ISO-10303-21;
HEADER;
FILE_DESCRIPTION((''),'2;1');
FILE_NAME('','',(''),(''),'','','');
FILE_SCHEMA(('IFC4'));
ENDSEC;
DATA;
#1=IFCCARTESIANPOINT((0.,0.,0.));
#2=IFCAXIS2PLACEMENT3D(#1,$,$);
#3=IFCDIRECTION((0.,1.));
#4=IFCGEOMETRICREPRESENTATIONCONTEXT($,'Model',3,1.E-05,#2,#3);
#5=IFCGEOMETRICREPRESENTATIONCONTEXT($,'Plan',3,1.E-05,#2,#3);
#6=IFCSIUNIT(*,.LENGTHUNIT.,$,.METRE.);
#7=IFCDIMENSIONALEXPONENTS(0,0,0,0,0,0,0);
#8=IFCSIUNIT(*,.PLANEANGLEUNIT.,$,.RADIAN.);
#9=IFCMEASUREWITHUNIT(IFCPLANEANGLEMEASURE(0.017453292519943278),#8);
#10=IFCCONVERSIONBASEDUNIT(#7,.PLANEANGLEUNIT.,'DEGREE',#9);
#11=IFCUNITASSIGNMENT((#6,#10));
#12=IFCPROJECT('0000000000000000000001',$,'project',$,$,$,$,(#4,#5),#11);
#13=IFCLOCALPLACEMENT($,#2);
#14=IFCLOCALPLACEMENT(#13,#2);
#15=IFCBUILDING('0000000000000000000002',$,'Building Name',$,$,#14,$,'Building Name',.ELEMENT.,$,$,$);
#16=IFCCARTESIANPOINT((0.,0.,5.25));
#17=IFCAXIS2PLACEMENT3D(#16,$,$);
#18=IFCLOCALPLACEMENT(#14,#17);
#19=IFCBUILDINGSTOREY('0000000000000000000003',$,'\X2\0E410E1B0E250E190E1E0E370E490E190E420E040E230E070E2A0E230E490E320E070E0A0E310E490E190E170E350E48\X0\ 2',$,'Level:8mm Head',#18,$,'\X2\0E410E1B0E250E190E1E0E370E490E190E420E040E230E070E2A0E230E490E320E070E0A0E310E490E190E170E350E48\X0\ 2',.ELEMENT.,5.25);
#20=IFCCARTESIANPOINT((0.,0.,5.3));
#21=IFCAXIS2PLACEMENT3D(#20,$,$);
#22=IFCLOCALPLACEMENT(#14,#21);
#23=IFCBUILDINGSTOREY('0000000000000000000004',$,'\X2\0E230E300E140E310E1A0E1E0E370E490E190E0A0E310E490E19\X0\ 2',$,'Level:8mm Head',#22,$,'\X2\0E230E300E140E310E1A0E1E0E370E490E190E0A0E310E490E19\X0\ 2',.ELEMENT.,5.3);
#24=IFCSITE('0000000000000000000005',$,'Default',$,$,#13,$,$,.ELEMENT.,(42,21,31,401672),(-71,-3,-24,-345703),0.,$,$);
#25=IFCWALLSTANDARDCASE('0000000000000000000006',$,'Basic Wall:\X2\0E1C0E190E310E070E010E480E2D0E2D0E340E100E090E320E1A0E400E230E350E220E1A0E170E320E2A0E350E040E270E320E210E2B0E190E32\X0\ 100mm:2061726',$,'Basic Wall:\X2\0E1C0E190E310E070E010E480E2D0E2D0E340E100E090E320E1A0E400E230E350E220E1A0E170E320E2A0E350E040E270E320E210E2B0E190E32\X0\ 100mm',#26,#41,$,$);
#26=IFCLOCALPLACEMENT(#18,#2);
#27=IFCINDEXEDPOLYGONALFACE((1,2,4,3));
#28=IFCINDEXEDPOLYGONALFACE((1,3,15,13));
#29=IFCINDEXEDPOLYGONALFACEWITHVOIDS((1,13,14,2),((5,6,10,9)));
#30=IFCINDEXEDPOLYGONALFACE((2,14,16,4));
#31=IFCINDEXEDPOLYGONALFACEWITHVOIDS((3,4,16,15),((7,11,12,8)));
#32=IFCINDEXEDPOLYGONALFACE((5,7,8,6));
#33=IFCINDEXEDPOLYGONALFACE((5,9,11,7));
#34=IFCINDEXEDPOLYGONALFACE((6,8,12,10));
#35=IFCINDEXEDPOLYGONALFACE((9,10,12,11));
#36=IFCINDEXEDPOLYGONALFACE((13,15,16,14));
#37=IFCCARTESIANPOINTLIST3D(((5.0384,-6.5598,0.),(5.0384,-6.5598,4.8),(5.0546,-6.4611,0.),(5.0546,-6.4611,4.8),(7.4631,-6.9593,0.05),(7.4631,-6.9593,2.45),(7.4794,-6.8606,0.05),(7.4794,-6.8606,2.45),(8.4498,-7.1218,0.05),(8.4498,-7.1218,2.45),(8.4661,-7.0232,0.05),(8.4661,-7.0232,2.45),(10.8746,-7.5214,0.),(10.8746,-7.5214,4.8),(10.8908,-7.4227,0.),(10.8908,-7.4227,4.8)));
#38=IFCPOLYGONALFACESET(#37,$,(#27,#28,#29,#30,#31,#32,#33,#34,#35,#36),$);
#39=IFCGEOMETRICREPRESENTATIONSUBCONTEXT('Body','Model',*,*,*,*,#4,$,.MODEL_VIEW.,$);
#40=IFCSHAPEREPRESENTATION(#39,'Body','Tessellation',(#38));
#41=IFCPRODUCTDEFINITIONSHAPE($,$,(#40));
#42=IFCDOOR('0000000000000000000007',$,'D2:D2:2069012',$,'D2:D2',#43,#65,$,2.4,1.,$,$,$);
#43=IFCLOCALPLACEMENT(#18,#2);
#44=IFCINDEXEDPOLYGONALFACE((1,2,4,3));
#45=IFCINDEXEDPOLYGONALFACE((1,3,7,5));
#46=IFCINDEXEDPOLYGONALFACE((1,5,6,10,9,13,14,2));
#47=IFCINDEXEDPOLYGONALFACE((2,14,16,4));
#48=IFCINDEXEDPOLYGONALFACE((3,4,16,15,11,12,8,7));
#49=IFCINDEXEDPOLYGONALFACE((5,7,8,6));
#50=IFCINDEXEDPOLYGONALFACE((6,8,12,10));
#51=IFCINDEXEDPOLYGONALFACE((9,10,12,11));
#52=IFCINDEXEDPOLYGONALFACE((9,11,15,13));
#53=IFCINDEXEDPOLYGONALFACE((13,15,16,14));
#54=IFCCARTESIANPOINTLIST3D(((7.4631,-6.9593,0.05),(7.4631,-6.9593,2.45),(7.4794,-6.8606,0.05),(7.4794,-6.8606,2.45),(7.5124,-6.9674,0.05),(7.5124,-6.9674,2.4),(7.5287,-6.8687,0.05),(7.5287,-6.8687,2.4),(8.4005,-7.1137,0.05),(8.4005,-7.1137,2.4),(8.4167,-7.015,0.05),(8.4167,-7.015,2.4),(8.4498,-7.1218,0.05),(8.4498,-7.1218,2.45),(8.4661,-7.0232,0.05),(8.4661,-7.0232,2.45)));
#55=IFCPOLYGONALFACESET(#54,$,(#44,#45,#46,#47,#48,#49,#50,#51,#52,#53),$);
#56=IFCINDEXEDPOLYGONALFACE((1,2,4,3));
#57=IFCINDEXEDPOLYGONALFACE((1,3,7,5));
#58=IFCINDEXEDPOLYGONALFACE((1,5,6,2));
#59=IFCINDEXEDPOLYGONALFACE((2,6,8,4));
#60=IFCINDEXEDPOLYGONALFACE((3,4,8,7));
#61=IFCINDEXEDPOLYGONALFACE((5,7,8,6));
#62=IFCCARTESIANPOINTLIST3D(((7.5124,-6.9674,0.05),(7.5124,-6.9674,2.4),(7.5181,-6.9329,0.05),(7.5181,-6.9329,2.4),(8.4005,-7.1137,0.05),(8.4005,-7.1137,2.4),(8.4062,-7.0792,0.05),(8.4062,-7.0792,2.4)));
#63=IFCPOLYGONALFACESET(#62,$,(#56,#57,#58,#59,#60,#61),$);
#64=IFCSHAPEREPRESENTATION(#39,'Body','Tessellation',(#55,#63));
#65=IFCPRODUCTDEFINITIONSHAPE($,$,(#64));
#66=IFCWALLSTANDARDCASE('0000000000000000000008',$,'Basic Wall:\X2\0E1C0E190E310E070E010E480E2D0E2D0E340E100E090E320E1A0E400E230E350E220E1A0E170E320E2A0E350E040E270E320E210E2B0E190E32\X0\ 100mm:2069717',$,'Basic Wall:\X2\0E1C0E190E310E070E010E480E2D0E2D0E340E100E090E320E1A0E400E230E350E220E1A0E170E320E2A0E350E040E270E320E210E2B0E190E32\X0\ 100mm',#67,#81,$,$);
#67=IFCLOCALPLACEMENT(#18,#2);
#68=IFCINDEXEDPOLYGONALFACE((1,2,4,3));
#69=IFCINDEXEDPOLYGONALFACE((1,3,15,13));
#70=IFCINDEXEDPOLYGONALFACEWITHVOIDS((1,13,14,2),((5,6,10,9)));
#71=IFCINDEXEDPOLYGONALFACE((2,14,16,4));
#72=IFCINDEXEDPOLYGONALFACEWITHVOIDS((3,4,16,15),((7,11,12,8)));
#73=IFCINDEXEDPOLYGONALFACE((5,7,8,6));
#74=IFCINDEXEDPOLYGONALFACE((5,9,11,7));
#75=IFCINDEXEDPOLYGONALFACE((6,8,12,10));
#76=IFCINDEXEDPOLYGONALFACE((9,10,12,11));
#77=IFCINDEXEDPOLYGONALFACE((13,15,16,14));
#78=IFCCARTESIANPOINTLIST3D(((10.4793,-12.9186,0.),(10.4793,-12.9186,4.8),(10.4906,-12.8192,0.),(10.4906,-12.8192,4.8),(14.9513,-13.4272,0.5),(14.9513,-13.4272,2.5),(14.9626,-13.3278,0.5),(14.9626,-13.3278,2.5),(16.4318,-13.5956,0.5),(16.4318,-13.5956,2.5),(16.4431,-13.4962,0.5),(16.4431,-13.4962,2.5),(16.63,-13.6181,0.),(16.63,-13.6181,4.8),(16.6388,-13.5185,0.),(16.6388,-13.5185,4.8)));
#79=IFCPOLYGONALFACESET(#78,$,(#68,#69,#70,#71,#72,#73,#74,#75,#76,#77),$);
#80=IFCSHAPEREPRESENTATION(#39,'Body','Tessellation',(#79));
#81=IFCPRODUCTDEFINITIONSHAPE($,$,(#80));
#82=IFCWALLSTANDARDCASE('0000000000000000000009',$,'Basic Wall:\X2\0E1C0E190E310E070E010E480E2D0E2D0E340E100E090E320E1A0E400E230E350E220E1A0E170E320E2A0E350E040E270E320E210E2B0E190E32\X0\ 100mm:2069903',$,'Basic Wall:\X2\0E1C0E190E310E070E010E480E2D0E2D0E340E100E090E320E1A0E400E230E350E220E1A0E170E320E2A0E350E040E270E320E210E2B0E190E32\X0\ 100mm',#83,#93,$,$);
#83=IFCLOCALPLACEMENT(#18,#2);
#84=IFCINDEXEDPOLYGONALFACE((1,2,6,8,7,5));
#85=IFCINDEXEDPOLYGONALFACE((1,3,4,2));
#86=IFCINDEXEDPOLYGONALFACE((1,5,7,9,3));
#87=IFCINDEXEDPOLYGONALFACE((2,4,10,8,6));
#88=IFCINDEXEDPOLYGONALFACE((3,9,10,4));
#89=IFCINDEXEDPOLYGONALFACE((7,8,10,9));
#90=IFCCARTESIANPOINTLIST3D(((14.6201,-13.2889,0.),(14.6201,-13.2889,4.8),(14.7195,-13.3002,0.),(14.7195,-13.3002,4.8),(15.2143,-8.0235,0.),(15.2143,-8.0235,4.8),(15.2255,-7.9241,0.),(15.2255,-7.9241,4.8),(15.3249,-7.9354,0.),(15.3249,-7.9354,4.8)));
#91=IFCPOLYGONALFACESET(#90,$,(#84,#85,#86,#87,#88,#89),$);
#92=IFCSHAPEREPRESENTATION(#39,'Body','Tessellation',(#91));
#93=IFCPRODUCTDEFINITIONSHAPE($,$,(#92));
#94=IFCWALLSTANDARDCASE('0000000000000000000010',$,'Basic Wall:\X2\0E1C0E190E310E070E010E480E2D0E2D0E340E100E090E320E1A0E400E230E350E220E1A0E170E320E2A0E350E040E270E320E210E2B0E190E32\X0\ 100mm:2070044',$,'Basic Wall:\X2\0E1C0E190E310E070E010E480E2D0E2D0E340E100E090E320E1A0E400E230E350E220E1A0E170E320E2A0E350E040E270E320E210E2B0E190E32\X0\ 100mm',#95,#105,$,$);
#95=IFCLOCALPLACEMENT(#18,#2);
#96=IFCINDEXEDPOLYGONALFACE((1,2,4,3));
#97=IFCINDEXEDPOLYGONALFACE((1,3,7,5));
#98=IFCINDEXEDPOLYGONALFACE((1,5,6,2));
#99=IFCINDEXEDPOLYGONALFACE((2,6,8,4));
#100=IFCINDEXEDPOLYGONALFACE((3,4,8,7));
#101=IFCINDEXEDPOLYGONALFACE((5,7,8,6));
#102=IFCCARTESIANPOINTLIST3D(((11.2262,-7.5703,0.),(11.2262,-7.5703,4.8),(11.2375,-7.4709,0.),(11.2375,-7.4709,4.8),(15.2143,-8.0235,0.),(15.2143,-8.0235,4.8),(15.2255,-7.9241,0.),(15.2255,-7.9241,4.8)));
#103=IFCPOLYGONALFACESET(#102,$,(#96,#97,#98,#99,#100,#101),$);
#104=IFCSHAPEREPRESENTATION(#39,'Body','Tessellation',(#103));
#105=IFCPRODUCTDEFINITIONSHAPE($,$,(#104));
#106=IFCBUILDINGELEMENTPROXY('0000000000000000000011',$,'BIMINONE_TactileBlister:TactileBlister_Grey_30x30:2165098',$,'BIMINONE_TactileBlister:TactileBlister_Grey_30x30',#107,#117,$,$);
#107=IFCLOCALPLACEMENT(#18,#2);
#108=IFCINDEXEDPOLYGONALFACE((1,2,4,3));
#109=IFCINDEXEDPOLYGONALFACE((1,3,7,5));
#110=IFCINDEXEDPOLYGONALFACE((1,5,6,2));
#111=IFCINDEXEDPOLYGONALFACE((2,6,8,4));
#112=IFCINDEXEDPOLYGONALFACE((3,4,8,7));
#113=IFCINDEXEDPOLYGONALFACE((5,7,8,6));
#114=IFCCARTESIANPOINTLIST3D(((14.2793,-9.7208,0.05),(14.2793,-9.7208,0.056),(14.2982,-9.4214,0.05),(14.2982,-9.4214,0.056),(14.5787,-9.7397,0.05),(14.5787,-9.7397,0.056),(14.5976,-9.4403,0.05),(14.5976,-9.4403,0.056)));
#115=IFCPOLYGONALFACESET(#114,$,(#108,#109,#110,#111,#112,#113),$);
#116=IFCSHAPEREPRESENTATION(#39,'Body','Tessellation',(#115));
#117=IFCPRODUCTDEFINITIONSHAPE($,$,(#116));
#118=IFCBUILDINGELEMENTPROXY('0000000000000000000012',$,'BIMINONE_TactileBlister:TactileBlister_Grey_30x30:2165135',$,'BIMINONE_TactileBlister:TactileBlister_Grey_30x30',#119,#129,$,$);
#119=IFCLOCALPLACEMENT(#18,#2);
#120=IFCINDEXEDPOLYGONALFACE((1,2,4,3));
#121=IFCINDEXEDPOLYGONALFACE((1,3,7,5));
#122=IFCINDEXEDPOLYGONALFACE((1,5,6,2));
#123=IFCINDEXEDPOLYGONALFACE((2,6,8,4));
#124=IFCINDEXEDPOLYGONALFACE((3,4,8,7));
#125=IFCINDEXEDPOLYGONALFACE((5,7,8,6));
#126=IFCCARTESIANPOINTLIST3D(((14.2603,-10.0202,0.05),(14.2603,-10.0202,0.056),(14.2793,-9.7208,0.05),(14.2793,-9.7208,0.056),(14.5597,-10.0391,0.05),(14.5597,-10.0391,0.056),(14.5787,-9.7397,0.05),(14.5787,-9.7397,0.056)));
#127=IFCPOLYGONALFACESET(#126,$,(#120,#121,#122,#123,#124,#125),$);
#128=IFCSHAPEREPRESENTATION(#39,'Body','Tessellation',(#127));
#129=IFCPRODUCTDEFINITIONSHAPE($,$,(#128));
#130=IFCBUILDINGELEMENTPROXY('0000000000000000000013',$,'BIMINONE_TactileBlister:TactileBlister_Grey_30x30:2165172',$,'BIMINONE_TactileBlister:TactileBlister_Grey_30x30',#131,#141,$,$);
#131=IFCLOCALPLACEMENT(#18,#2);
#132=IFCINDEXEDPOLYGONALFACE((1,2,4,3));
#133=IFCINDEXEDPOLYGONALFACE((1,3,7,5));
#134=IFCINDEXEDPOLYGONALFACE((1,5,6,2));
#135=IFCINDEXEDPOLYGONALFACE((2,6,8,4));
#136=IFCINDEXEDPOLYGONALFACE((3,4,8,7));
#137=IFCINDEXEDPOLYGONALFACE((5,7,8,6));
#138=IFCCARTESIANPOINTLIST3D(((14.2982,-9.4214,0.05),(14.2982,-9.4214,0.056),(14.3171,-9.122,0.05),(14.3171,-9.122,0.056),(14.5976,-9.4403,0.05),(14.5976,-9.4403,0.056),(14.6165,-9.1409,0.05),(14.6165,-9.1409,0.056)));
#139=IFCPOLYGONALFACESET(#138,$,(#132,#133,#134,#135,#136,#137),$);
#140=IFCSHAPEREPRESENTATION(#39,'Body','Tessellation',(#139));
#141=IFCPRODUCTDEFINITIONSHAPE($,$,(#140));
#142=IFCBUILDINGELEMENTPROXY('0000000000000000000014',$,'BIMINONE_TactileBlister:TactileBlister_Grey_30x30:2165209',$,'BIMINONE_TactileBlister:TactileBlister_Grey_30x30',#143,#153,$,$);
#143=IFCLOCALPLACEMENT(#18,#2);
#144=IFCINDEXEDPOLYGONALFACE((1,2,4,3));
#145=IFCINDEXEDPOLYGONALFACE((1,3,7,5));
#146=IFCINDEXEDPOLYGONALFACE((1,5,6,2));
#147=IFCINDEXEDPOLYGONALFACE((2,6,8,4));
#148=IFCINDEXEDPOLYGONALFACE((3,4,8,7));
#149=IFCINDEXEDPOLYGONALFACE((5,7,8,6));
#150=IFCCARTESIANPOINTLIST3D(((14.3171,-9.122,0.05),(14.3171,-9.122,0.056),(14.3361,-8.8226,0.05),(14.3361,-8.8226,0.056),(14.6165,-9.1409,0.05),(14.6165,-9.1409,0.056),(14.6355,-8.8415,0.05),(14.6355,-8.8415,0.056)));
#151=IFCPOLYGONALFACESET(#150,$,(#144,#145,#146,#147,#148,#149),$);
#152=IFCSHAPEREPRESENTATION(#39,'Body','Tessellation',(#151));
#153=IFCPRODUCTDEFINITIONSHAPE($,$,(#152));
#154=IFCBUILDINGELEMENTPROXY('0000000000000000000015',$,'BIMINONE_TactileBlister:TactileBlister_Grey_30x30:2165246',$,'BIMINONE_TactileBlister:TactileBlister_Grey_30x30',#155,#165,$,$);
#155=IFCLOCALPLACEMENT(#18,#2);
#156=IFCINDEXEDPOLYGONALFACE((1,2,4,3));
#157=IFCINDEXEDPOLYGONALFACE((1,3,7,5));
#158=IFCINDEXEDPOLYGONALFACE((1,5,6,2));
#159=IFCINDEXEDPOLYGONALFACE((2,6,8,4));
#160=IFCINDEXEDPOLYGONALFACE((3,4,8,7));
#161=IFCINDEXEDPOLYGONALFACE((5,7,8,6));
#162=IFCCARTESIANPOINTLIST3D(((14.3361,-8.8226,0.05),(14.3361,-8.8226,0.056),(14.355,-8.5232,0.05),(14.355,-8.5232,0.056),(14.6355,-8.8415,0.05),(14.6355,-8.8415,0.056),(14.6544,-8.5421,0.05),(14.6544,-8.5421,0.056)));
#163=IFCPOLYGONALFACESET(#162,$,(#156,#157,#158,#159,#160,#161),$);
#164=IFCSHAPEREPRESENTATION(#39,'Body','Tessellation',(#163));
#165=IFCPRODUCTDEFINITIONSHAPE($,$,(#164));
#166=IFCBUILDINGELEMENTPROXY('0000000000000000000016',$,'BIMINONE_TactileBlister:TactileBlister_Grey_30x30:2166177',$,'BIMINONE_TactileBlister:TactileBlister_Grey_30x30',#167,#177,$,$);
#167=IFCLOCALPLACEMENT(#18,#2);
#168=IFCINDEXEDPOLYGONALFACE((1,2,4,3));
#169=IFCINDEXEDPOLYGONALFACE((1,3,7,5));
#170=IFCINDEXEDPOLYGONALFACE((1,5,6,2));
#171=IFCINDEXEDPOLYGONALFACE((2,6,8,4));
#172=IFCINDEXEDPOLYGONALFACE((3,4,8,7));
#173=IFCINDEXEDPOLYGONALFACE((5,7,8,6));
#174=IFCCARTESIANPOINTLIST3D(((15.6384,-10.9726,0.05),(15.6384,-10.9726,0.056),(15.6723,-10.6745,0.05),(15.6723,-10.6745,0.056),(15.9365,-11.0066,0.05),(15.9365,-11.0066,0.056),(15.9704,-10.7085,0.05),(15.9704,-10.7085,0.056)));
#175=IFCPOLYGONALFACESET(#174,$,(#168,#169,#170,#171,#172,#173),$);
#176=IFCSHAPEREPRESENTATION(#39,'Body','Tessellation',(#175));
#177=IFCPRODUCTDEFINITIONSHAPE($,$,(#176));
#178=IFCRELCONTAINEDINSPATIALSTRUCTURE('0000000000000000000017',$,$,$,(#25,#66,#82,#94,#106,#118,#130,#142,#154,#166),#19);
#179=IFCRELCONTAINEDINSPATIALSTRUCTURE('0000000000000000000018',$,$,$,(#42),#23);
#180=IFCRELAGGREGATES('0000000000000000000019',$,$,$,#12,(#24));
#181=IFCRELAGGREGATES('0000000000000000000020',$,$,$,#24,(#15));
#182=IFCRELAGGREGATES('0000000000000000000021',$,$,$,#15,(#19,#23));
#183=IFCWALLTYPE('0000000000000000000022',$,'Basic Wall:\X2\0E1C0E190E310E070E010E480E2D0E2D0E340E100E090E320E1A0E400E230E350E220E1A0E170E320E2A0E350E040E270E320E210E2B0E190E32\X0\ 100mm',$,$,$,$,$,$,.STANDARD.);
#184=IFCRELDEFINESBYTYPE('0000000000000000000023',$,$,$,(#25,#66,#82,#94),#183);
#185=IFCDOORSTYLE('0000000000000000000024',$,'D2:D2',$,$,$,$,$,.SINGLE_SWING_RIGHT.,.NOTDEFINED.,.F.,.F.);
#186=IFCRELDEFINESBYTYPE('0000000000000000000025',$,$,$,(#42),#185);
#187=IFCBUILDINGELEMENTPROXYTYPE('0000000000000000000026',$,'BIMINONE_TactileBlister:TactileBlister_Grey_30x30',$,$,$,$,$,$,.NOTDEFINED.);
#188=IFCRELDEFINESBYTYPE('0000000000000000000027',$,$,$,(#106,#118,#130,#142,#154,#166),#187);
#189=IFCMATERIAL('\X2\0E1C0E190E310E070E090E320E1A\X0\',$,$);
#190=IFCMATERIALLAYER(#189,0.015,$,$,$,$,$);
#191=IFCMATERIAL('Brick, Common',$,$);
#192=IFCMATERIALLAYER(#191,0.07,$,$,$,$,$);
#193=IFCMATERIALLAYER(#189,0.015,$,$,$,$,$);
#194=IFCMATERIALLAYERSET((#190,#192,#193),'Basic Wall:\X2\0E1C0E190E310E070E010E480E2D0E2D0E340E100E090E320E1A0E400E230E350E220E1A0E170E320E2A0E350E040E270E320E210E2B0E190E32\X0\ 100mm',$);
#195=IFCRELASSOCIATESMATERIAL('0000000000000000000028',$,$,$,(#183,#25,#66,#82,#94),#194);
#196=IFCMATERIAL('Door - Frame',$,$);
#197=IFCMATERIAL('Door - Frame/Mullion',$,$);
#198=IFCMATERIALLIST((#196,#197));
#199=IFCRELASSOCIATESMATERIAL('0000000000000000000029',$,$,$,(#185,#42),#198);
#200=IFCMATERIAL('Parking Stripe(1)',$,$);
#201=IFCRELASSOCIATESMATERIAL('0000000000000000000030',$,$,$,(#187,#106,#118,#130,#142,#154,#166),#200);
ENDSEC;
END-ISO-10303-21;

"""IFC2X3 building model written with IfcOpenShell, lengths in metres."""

from ifc_helpers import new_model, entity, si_unit, converted_unit, direction, frame, frame_2d, origin, origin_2d_with_axis, place, context, subcontext, project, spatial, polyline, rectangle, outline, extrude, source, transform, mapped, material, material_list, layer, layer_set, layer_usage, type_object, type_shapes, element, fill, save


model = new_model("IFC2X3")

# Units and contexts
model_context = context("Model", 3, precision=1e-05, world=origin(), true_north=direction((0.0, 1.0)))
plan_context = context("Plan", 3, precision=1e-05, world=origin(), true_north=direction((0.0, 1.0)))
body_context = subcontext(model_context, "Body", "Model", "MODEL_VIEW")
ifc_project = project(units=[si_unit("LENGTHUNIT", "METRE"), converted_unit("PLANEANGLEUNIT", "DEGREE", entity("IfcPlaneAngleMeasure", 0.017453292519943278), si_unit("PLANEANGLEUNIT", "RADIAN"), dimensions=[0, 0, 0, 0, 0, 0, 0])], contexts=[model_context, plan_context])

# Site, building, storey
site_placement = place(None, origin())
site = spatial("IfcSite", under=ifc_project, at=site_placement, Name="Default", CompositionType="ELEMENT", RefLatitude=(42, 21, 31, 401672), RefLongitude=(-71, -3, -24, -345703), RefElevation=0.0)
building_placement = place(site_placement, origin())
building = spatial("IfcBuilding", under=site, at=building_placement, Name="Building Name", LongName="Building Name", CompositionType="ELEMENT")
storey_1_placement = place(building_placement, frame((0.0, 0.0, 5.25)))
storey_1 = spatial("IfcBuildingStorey", under=building, at=storey_1_placement, Name="แปลนพื้นโครงสร้างชั้นที่ 2", ObjectType="Level:8mm Head", LongName="แปลนพื้นโครงสร้างชั้นที่ 2", CompositionType="ELEMENT", Elevation=5.25)

# Wall, openings
ifc_material_1 = material(Name="ผนังฉาบ")
ifc_layer_1 = layer(ifc_material_1, 0.015)
ifc_material_2 = material(Name="Brick, Common")
ifc_layer_2 = layer(ifc_material_2, 0.07)
ifc_layer_3 = layer(ifc_material_1, 0.015)
ifc_layer_set = layer_set([ifc_layer_1, ifc_layer_2, ifc_layer_3], Name="Basic Wall:ผนังก่ออิฐฉาบเรียบทาสีความหนา 100mm")
wall_type = type_object("IfcWallType", Name="Basic Wall:ผนังก่ออิฐฉาบเรียบทาสีความหนา 100mm", PredefinedType="STANDARD", material=ifc_layer_set)
ifc_layer_usage_1 = layer_usage(ifc_layer_set, "AXIS2", "POSITIVE", -0.05)
wall_1_placement = place(storey_1_placement, frame((10.8827, -7.472, 0.0), z_axis=(0.0, 0.0, 1.0), x_axis=(-0.986697, 0.16257, 0.0)))
wall_1 = element("IfcWallStandardCase", 1, at=wall_1_placement, inside=storey_1, type_object=wall_type, material=ifc_layer_usage_1, Name="Basic Wall:ผนังก่ออิฐฉาบเรียบทาสีความหนา 100mm:2061726", ObjectType="Basic Wall:ผนังก่ออิฐฉาบเรียบทาสีความหนา 100mm", context=body_context, shape_type="SweptSolid", body=[
    extrude(rectangle(XDim=5.9149, YDim=0.1, at=frame_2d((2.9575, 0.0), x_axis=(-1.0, 0.0))), origin(), (0.0, 0.0, 1.0), 4.8),
])
opening_1_placement = place(wall_1_placement, frame((11.9527, -5.6034, 0.05), z_axis=(0.0, 0.0, 1.0), x_axis=(-0.986697, -0.16257, 0.0)))
element("IfcOpeningElement", 2, at=opening_1_placement, cuts=wall_1, ObjectType="Opening", context=body_context, shape_type="SweptSolid", body=[
    extrude(rectangle(XDim=2.4, YDim=1.0, at=origin_2d_with_axis()), frame((8.2205, -5.4382, 1.2), z_axis=(-0.16257, -0.986697, 0.0), x_axis=(0.0, 0.0, 1.0)), (0.0, 0.0, 1.0), 3.048),
])
opening_2_placement = place(wall_1_placement, frame((2.4575, -0.05, 0.05)))
opening_2 = element("IfcOpeningElement", 3, at=opening_2_placement, cuts=wall_1, ObjectType="Opening", context=body_context, shape_type="SweptSolid", body=[
    extrude(rectangle(XDim=2.4, YDim=1.0, at=frame_2d((1.2, 0.5), x_axis=(1.0, 0.0))), frame((0.0, 0.0, 0.0), z_axis=(0.0, 1.0, 0.0), x_axis=(0.0, 0.0, 1.0)), (0.0, 0.0, 1.0), 0.1),
])

# Shared definitions
storey_2_placement = place(building_placement, frame((0.0, 0.0, 5.3)))
storey_2 = spatial("IfcBuildingStorey", under=building, at=storey_2_placement, Name="ระดับพื้นชั้น 2", ObjectType="Level:8mm Head", LongName="ระดับพื้นชั้น 2", CompositionType="ELEMENT", Elevation=5.3)

# Door
ifc_material_3 = material(Name="Door - Frame")
ifc_material_4 = material(Name="Door - Frame/Mullion")
ifc_material_list = material_list([ifc_material_3, ifc_material_4])
door_style = type_object("IfcDoorStyle", Name="D2:D2", ConstructionType="NOTDEFINED", OperationType="SINGLE_SWING_RIGHT", ParameterTakesPrecedence=False, Sizeable=False, material=ifc_material_list)
shared_shape_1 = source(origin(), body_context, "Body", "SweptSolid", [
    extrude(outline(polyline([(-0.5, -1.1875), (-0.45, -1.1875), (-0.45, 1.1625), (0.45, 1.1625), (0.45, -1.1875), (0.5, -1.1875), (0.5, 1.2125), (-0.5, 1.2125), (-0.5, -1.1875)])), frame((0.5, 0.1, 1.1875), z_axis=(0.0, -1.0, 0.0), x_axis=(1.0, 0.0, 0.0)), (0.0, 0.0, 1.0), 0.1),
    extrude(rectangle(XDim=0.035, YDim=0.9, at=origin_2d_with_axis()), frame((0.5, 0.0825, 0.0), z_axis=(0.0, 0.0, 1.0), x_axis=(0.0, -1.0, 0.0)), (0.0, 0.0, 1.0), 2.35),
])
type_shapes(door_style, [shared_shape_1])
door_placement = place(opening_2_placement, origin())
door = element("IfcDoor", 4, at=door_placement, inside=storey_2, type_object=door_style, material=ifc_material_list, Name="D2:D2:2069012", ObjectType="D2:D2", OverallHeight=2.4, OverallWidth=1.0, context=body_context, shape_type="MappedRepresentation", body=[
    mapped(shared_shape_1, transform((0.0, 0.0, 0.0), scale=1.0)),
])
fill(opening_2, door)

# Wall, openings
ifc_layer_usage_2 = layer_usage(ifc_layer_set, "AXIS2", "POSITIVE", -0.05)
wall_2_placement = place(storey_1_placement, frame((10.485, -12.8689, 0.0), z_axis=(0.0, 0.0, 1.0), x_axis=(0.993595, -0.113, 0.0)))
wall_2 = element("IfcWallStandardCase", 5, at=wall_2_placement, inside=storey_1, type_object=wall_type, material=ifc_layer_usage_2, Name="Basic Wall:ผนังก่ออิฐฉาบเรียบทาสีความหนา 100mm:2069717", ObjectType="Basic Wall:ผนังก่ออิฐฉาบเรียบทาสีความหนา 100mm", context=body_context, shape_type="SweptSolid", body=[
    extrude(outline(polyline([(6.1903, -0.05), (6.1878, 0.05), (4.2561, 0.05), (4.1561, 0.05), (0.0, 0.05), (0.0, -0.05), (6.1903, -0.05)])), origin(), (0.0, 0.0, 1.0), 4.8),
])
opening_3_placement = place(wall_2_placement, frame((-11.872, 11.6017, 0.05), z_axis=(0.0, 0.0, 1.0), x_axis=(0.993595, 0.113, 0.0)))
element("IfcOpeningElement", 6, at=opening_3_placement, cuts=wall_2, ObjectType="Opening", context=body_context, shape_type="SweptSolid", body=[
    extrude(rectangle(XDim=2.0, YDim=1.49, at=frame_2d((0.0, 0.0), x_axis=(0.0, 1.0))), frame((15.5306, -14.9263, 1.45), z_axis=(0.113, 0.993595, 0.0), x_axis=(-0.993595, 0.113, 0.0)), (0.0, 0.0, 1.0), 3.048),
])
opening_4_placement = place(wall_2_placement, frame((5.9908, 0.05, 0.5)))
element("IfcOpeningElement", 7, at=opening_4_placement, cuts=wall_2, ObjectType="Opening", context=body_context, shape_type="SweptSolid", body=[
    extrude(rectangle(XDim=2.0, YDim=1.49, at=frame_2d((1.0, 0.745), x_axis=(1.0, 0.0))), frame((0.0, 0.0, 0.0), z_axis=(0.0, -1.0, 0.0), x_axis=(0.0, 0.0, 1.0)), (0.0, 0.0, 1.0), 0.1),
])

# Walls
ifc_layer_usage_3 = layer_usage(ifc_layer_set, "AXIS2", "POSITIVE", -0.05)
wall_3_placement = place(storey_1_placement, frame((14.6698, -13.2946, 0.0), z_axis=(0.0, 0.0, 1.0), x_axis=(0.112128, 0.993694, 0.0)))
element("IfcWallStandardCase", 8, at=wall_3_placement, inside=storey_1, type_object=wall_type, material=ifc_layer_usage_3, Name="Basic Wall:ผนังก่ออิฐฉาบเรียบทาสีความหนา 100mm:2069903", ObjectType="Basic Wall:ผนังก่ออิฐฉาบเรียบทาสีความหนา 100mm", context=body_context, shape_type="SweptSolid", body=[
    extrude(outline(polyline([(5.3989, -0.05), (5.3989, 0.05), (5.2989, 0.05), (0.0001, 0.05), (0.0, -0.05), (5.3989, -0.05)])), origin(), (0.0, 0.0, 1.0), 4.8),
])
ifc_layer_usage_4 = layer_usage(ifc_layer_set, "AXIS2", "NEGATIVE", 0.05)
wall_4_placement = place(storey_1_placement, frame((11.2318, -7.5206, 0.0), z_axis=(0.0, 0.0, 1.0), x_axis=(0.993606, -0.112906, 0.0)))
element("IfcWallStandardCase", 9, at=wall_4_placement, inside=storey_1, type_object=wall_type, material=ifc_layer_usage_4, Name="Basic Wall:ผนังก่ออิฐฉาบเรียบทาสีความหนา 100mm:2070044", ObjectType="Basic Wall:ผนังก่ออิฐฉาบเรียบทาสีความหนา 100mm", context=body_context, shape_type="SweptSolid", body=[
    extrude(outline(polyline([(4.0137, -0.05), (4.0137, 0.05), (0.0, 0.05), (0.0, -0.05), (4.0137, -0.05)])), origin(), (0.0, 0.0, 1.0), 4.8),
])

# Building element proxies
ifc_material_5 = material(Name="Parking Stripe(1)")
building_element_proxy_type = type_object("IfcBuildingElementProxyType", Name="BIMINONE_TactileBlister:TactileBlister_Grey_30x30", PredefinedType="NOTDEFINED", material=ifc_material_5)
shared_shape_2 = source(origin(), body_context, "Body", "SweptSolid", [
    extrude(rectangle(XDim=0.3, YDim=0.3, at=origin_2d_with_axis()), frame((0.15, -0.15, 0.0), z_axis=(0.0, 0.0, 1.0), x_axis=(-1.0, 0.0, 0.0)), (0.0, 0.0, 1.0), 0.006),
])
type_shapes(building_element_proxy_type, [shared_shape_2])
for number, where, z_axis, x_axis, name in (
    (10, (14.2793, -9.7208, 0.05), (0.0, 0.0, 1.0), (0.063097, 0.998007, 0.0), "BIMINONE_TactileBlister:TactileBlister_Grey_30x30:2165098"),
    (11, (14.2603, -10.0202, 0.05), (0.0, 0.0, 1.0), (0.063097, 0.998007, 0.0), "BIMINONE_TactileBlister:TactileBlister_Grey_30x30:2165135"),
    (12, (14.2982, -9.4214, 0.05), (0.0, 0.0, 1.0), (0.063097, 0.998007, 0.0), "BIMINONE_TactileBlister:TactileBlister_Grey_30x30:2165172"),
    (13, (14.3171, -9.122, 0.05), (0.0, 0.0, 1.0), (0.063097, 0.998007, 0.0), "BIMINONE_TactileBlister:TactileBlister_Grey_30x30:2165209"),
    (14, (14.3361, -8.8226, 0.05), (0.0, 0.0, 1.0), (0.063097, 0.998007, 0.0), "BIMINONE_TactileBlister:TactileBlister_Grey_30x30:2165246"),
    (15, (15.9704, -10.7085, 0.05), (0.0, 0.0, 1.0), (-0.113147, -0.993578, 0.0), "BIMINONE_TactileBlister:TactileBlister_Grey_30x30:2166177"),
):
    element("IfcBuildingElementProxy", number, at=place(storey_1_placement, frame(where, z_axis=z_axis, x_axis=x_axis)), inside=storey_1, type_object=building_element_proxy_type, material=ifc_material_5, Name=name, ObjectType="BIMINONE_TactileBlister:TactileBlister_Grey_30x30", context=body_context, shape_type="MappedRepresentation", body=[
        mapped(shared_shape_2, transform((0.0, 0.0, 0.0), scale=1.0)),
    ])

save(model, "model.ifc")
